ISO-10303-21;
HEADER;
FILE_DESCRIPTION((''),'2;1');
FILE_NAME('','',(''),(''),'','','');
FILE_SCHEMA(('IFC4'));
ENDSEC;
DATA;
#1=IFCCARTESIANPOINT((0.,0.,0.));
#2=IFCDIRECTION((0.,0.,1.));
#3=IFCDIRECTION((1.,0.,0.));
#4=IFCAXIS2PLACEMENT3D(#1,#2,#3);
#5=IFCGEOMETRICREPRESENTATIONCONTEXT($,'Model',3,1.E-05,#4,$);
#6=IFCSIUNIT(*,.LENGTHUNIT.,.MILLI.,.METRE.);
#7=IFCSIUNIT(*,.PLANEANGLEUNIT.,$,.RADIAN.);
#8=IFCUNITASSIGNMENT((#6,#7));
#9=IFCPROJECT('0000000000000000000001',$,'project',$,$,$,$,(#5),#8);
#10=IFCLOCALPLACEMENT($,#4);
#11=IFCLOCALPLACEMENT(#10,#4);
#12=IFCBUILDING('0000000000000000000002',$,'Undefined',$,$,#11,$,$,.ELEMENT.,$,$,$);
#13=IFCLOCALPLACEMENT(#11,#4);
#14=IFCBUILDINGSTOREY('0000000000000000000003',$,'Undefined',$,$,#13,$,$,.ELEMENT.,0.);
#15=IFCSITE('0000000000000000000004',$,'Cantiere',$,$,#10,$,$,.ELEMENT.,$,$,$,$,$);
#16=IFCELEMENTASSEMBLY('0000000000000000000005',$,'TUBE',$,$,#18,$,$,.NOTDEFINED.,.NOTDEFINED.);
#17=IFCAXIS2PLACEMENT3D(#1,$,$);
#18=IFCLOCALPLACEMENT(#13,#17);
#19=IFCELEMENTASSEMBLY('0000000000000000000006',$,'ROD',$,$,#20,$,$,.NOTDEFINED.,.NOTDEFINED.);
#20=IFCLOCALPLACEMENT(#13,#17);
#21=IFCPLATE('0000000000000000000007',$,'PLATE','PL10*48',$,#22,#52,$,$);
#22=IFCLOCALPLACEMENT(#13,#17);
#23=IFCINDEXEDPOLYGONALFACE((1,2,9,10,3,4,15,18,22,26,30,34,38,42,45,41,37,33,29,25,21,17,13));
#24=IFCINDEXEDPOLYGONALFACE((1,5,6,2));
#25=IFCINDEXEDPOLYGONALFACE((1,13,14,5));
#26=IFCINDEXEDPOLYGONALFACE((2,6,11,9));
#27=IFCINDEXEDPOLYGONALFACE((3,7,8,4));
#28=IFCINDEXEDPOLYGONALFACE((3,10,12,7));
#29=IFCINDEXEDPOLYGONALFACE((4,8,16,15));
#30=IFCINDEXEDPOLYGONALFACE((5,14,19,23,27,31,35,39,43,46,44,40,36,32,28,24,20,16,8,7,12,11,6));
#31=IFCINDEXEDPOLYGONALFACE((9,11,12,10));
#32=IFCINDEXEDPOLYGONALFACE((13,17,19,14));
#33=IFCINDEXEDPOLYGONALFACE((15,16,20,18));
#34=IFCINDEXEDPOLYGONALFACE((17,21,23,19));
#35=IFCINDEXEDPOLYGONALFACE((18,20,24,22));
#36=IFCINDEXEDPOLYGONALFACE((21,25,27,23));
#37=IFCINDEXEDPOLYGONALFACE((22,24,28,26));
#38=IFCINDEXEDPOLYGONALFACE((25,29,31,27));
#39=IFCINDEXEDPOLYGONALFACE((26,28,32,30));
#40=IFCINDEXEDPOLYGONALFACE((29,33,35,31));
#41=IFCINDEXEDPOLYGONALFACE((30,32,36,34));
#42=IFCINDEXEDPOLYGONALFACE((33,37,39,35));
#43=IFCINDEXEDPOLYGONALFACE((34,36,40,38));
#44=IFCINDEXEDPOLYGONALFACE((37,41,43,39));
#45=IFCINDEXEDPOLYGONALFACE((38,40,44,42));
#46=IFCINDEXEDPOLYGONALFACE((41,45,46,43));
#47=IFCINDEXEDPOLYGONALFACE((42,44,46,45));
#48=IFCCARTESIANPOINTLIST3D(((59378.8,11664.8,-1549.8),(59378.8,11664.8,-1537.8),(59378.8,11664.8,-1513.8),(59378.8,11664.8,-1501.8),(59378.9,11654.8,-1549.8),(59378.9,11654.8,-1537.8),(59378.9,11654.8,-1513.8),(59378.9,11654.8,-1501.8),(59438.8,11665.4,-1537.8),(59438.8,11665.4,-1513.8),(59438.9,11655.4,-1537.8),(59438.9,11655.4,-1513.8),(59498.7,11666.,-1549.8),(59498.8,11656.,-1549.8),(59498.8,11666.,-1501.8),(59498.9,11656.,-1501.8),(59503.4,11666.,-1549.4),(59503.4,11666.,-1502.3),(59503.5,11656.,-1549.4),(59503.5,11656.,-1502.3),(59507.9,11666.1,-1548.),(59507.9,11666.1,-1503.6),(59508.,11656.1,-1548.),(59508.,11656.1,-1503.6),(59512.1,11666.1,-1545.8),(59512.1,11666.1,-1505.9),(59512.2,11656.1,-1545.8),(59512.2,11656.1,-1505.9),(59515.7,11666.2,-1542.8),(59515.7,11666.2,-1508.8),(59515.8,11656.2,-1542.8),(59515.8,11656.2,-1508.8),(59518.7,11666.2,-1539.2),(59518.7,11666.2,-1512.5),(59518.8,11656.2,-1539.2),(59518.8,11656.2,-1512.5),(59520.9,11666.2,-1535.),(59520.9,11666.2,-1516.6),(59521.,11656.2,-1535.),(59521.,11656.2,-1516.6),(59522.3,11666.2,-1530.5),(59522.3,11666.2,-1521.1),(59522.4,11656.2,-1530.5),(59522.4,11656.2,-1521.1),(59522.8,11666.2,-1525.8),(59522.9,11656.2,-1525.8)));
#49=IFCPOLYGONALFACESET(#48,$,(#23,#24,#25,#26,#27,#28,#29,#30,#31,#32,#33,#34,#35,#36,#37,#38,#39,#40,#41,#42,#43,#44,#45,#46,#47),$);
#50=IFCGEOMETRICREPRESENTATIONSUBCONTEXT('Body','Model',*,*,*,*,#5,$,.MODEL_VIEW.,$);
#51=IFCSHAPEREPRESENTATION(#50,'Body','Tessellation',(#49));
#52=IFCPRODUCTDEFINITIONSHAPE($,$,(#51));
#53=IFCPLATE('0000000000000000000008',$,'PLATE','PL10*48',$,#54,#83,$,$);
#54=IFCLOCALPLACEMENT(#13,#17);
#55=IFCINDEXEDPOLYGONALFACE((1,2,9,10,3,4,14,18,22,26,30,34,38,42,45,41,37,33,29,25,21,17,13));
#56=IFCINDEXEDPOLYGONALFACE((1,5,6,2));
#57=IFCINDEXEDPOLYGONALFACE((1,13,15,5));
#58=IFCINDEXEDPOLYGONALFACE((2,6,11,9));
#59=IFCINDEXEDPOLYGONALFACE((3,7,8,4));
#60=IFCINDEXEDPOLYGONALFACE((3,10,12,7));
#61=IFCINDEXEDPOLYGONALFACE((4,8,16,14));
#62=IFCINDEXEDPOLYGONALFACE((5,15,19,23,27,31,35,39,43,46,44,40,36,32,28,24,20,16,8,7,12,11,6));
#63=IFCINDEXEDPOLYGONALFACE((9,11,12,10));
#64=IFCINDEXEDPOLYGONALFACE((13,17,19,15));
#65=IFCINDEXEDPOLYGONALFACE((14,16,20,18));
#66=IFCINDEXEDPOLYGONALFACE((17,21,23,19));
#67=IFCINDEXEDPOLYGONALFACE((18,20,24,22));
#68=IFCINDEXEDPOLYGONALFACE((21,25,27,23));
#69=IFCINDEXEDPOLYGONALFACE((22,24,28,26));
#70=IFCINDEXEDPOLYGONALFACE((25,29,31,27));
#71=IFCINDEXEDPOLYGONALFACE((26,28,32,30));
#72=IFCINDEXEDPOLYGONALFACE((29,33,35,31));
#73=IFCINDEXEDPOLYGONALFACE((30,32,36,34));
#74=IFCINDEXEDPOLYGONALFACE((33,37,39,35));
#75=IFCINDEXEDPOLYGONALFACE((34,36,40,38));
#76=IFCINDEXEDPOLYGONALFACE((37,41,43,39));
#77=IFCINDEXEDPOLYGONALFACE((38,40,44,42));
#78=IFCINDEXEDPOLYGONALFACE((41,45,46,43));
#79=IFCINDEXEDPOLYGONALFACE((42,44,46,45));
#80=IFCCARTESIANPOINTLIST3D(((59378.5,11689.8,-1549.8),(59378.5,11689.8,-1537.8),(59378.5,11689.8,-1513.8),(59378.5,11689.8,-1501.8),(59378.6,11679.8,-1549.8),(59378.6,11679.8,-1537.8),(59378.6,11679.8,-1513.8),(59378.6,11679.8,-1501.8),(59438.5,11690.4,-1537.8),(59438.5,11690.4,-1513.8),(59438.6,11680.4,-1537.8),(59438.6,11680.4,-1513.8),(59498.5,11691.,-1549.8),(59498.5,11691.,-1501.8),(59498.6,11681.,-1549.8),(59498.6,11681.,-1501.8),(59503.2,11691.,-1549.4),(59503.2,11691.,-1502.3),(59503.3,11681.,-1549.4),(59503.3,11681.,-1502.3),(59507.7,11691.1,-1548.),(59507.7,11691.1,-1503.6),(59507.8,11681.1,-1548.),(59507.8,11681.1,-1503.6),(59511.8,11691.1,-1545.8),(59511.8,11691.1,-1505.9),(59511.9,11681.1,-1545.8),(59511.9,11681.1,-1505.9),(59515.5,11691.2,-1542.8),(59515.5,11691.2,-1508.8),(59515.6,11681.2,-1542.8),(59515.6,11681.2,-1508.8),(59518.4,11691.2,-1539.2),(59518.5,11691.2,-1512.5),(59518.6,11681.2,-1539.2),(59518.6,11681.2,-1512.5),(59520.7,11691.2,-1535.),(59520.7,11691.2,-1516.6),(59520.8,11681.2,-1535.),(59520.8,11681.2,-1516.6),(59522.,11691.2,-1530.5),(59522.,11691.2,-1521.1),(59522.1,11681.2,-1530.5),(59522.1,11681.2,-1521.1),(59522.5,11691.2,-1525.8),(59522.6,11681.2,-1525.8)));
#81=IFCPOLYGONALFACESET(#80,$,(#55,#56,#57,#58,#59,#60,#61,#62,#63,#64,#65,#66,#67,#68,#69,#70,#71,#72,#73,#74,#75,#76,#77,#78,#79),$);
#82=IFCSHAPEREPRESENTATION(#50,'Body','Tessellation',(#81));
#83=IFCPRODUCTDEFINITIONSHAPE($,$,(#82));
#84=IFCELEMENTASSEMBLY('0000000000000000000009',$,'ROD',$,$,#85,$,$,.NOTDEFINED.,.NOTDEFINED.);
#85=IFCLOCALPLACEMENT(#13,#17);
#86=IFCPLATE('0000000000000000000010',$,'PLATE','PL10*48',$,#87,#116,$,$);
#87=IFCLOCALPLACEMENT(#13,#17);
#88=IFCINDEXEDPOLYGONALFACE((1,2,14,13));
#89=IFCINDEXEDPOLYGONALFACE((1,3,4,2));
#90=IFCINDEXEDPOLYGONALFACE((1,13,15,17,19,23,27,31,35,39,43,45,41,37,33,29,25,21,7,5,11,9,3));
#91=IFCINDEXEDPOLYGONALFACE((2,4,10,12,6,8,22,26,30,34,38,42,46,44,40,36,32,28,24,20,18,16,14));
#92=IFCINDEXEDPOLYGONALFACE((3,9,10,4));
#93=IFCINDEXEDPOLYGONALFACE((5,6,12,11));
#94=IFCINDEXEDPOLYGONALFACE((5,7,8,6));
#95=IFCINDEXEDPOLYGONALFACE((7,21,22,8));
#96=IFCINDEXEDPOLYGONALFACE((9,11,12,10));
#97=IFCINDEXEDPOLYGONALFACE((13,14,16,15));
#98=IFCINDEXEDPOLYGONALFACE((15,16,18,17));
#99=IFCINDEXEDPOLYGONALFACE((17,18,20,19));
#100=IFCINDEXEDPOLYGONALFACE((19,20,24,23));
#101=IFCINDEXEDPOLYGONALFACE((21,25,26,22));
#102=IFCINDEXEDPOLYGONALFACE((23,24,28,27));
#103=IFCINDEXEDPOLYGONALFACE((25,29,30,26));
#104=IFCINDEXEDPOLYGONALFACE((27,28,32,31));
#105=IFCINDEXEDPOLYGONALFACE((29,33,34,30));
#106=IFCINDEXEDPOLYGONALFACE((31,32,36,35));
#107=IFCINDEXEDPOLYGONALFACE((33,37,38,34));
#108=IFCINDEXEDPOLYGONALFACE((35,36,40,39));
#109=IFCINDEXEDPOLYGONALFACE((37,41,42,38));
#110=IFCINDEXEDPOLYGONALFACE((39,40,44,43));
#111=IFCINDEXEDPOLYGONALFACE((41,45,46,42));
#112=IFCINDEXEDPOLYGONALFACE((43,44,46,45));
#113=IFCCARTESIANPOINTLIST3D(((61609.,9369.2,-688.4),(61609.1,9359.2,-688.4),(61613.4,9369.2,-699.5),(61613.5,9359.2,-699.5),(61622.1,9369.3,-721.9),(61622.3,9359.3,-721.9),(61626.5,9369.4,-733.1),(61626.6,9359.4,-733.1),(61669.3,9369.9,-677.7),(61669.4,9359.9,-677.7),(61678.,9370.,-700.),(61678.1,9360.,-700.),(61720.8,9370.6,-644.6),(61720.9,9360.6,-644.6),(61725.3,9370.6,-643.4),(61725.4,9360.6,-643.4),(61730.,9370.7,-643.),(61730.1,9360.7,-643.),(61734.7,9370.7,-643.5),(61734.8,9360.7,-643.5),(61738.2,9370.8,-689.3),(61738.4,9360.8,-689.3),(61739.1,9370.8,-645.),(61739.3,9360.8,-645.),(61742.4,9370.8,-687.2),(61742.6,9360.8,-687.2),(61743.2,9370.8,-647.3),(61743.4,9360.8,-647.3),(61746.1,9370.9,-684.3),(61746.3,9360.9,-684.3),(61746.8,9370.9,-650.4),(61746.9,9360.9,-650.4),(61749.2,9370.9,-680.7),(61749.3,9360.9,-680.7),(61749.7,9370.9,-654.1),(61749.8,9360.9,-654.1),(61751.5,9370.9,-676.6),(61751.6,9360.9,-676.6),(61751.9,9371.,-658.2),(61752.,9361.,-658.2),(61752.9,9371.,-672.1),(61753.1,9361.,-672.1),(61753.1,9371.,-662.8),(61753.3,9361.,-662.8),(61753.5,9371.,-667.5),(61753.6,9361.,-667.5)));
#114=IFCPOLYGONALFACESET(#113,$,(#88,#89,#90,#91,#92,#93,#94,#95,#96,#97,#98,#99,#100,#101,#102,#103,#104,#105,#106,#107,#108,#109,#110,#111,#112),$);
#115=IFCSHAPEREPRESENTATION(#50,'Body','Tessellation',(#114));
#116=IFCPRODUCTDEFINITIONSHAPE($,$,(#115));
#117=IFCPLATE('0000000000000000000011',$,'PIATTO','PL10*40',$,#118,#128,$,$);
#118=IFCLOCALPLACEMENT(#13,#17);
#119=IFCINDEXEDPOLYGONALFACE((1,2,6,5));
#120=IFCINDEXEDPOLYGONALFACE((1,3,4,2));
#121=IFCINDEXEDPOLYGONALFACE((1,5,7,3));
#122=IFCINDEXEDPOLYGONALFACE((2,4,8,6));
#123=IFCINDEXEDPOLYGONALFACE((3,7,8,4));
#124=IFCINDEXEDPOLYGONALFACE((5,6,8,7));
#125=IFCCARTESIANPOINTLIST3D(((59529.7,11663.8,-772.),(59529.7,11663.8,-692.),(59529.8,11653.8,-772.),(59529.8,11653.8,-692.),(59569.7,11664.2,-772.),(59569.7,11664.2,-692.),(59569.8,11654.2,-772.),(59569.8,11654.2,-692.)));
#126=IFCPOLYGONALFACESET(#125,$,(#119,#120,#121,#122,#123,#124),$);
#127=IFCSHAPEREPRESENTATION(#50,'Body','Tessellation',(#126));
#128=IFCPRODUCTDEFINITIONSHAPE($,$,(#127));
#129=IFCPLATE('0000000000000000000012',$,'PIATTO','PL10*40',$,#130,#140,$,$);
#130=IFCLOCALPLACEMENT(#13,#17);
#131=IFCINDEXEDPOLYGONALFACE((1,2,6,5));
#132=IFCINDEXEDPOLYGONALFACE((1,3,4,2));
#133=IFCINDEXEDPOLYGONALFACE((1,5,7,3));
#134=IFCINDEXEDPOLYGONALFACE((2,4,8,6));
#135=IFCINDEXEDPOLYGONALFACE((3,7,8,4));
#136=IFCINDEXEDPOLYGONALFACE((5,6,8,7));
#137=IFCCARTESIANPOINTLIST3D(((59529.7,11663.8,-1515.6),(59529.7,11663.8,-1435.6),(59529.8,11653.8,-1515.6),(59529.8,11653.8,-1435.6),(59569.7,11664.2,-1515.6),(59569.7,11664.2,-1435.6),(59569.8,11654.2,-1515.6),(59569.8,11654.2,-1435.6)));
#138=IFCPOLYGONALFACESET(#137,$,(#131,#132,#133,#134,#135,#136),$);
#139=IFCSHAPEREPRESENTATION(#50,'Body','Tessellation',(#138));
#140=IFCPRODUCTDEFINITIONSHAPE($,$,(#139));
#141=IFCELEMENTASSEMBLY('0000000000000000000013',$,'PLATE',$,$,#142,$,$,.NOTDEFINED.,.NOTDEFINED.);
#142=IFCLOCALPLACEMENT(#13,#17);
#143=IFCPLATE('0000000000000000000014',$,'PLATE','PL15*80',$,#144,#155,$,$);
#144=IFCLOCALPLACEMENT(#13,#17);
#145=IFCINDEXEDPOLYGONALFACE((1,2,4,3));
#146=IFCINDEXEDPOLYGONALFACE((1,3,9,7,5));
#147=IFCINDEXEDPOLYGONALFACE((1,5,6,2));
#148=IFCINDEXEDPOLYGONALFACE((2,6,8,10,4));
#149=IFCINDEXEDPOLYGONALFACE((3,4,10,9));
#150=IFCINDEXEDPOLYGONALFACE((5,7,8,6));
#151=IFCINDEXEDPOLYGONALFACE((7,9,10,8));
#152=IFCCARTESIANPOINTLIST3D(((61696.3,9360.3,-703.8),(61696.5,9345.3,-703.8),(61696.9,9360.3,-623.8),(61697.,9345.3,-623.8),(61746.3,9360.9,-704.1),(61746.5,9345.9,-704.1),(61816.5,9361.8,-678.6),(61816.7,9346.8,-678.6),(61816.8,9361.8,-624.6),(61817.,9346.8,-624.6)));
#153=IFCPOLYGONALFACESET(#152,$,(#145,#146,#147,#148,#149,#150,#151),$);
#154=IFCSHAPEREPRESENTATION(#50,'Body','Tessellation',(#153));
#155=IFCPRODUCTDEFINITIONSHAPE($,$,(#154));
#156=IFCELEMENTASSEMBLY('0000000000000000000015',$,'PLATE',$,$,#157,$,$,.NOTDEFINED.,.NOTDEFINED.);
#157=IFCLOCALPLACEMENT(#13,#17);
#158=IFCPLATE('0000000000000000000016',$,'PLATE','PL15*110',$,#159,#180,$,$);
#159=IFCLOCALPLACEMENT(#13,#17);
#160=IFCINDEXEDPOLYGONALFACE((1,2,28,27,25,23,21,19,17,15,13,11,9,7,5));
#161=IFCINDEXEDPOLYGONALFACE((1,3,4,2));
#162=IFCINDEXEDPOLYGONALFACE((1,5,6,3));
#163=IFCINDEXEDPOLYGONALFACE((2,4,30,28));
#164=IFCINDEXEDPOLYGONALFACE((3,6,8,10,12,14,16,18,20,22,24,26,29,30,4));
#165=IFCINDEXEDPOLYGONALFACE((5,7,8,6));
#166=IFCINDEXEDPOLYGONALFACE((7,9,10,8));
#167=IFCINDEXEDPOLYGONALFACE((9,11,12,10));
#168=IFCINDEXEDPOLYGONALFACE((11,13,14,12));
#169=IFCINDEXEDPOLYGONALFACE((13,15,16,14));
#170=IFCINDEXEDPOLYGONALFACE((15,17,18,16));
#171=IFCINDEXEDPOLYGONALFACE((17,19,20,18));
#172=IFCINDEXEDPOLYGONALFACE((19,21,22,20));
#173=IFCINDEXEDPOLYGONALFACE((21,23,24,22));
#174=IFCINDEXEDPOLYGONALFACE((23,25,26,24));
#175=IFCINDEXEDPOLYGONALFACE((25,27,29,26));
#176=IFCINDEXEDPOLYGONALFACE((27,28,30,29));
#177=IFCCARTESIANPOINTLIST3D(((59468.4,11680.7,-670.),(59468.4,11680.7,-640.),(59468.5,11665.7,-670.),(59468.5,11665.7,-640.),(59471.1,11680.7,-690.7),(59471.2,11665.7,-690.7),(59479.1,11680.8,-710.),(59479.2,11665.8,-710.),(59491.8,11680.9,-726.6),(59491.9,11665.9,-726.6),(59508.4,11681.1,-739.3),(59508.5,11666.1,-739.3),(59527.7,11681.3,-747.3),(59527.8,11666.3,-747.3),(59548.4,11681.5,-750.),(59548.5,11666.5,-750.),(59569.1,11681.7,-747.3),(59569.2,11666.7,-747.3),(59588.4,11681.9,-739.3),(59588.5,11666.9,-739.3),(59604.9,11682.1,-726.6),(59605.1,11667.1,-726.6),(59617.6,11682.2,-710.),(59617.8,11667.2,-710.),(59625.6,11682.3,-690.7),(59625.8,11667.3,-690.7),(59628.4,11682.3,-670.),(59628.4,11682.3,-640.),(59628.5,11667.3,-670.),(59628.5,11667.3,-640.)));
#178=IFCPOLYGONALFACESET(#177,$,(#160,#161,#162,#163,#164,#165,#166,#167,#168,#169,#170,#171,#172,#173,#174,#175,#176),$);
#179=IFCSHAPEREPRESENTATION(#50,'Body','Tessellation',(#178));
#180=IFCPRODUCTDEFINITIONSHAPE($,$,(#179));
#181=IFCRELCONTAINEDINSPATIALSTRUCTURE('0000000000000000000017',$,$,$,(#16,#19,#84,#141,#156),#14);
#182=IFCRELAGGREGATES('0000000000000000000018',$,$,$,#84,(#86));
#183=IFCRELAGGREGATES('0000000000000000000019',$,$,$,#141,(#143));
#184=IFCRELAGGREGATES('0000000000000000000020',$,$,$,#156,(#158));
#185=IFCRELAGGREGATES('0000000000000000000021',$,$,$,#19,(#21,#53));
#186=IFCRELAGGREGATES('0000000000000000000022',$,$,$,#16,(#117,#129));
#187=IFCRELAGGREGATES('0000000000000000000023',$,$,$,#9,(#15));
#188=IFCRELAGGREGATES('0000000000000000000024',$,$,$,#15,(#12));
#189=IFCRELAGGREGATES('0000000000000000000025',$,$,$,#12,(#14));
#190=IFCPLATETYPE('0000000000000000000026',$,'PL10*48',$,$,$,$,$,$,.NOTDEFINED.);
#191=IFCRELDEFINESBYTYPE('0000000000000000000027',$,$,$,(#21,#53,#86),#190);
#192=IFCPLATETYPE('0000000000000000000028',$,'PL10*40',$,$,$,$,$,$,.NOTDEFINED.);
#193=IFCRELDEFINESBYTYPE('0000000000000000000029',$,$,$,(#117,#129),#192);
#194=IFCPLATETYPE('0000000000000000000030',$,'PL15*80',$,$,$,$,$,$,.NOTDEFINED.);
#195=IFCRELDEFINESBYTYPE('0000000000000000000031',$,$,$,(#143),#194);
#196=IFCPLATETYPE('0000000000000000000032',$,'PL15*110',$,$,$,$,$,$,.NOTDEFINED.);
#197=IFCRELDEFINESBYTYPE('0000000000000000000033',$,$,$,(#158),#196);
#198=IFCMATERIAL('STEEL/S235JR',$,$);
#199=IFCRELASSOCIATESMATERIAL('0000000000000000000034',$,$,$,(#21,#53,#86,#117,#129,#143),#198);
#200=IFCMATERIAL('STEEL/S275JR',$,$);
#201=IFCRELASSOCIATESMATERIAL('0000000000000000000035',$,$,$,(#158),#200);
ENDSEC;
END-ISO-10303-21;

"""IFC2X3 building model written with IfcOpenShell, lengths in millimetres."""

from ifc_helpers import new_model, si_unit, frame, frame_2d, origin_with_axes, place, context, subcontext, project, spatial, polyline, circle_curve, parameter, trimmed, segment, composite_curve, outline, extrude, material, type_object, element, aggregate, save


model = new_model("IFC2X3")

# Units and contexts
model_context = context("Model", 3, precision=1e-05, world=origin_with_axes())
body_context = subcontext(model_context, "Body", "Model", "MODEL_VIEW")
ifc_project = project(units=[si_unit("LENGTHUNIT", "METRE", prefix="MILLI"), si_unit("PLANEANGLEUNIT", "RADIAN")], contexts=[model_context])

# Site, building, storey
site_placement = place(None, origin_with_axes())
site = spatial("IfcSite", under=ifc_project, at=site_placement, Name="Cantiere", CompositionType="ELEMENT")
building_placement = place(site_placement, origin_with_axes())
building = spatial("IfcBuilding", under=site, at=building_placement, Name="Undefined", CompositionType="ELEMENT")
storey_placement = place(building_placement, origin_with_axes())
storey = spatial("IfcBuildingStorey", under=building, at=storey_placement, Name="Undefined", CompositionType="ELEMENT", Elevation=0.0)

# Element assembly
assembly_1_placement = place(storey_placement, origin_with_axes())
assembly_1 = element("IfcElementAssembly", 1, at=assembly_1_placement, inside=storey, Name="TUBE", AssemblyPlace="NOTDEFINED", PredefinedType="NOTDEFINED")
ifc_material_1 = material(Name="STEEL/S235JR")

# Shared definitions
plate_type_1 = type_object("IfcPlateType", Name="PL10*48", PredefinedType="NOTDEFINED")

# Element assembly, plates
assembly_2_placement = place(storey_placement, origin_with_axes())
assembly_2 = element("IfcElementAssembly", 2, at=assembly_2_placement, inside=storey, Name="ROD", AssemblyPlace="NOTDEFINED", PredefinedType="NOTDEFINED")
plate_1_placement = place(assembly_2_placement, frame((59378.8, 11659.8, -1549.8), z_axis=(0.010137, -0.999949, 0.0), x_axis=(0.999949, 0.010137, -0.000205)))
plate_1 = element("IfcPlate", 3, at=plate_1_placement, type_object=plate_type_1, material=ifc_material_1, Name="PLATE", Description="PL10*48", context=body_context, shape_type="SweptSolid", body=[
    extrude(outline(polyline([(0.0, 0.0), (120.0, 0.0), (124.7, 0.5), (129.2, 1.8), (133.3, 4.0), (137.0, 7.0), (140.0, 10.7), (142.2, 14.8), (143.5, 19.3), (144.0, 24.0), (144.0, 24.0), (143.5, 28.7), (142.2, 33.2), (140.0, 37.3), (137.0, 41.0), (133.3, 44.0), (129.2, 46.2), (124.7, 47.5), (120.0, 48.0), (0.0, 48.0), (0.0, 36.0), (60.0, 36.0), (60.0, 12.0), (0.0, 12.0), (0.0, 0.0)])), frame((0.0, 0.0, -5.0), z_axis=(0.0, 0.0, 1.0), x_axis=(1.0, 0.0, 0.0)), (0.0, 0.0, 1.0), 10.0),
])
plate_2_placement = place(assembly_2_placement, frame((59378.5, 11684.8, -1549.8), z_axis=(0.010137, -0.999949, 0.0), x_axis=(0.999949, 0.010137, -0.000205)))
plate_2 = element("IfcPlate", 4, at=plate_2_placement, type_object=plate_type_1, material=ifc_material_1, Name="PLATE", Description="PL10*48", context=body_context, shape_type="SweptSolid", body=[
    extrude(outline(polyline([(0.0, 0.0), (120.0, 0.0), (124.7, 0.5), (129.2, 1.8), (133.3, 4.0), (137.0, 7.0), (140.0, 10.7), (142.2, 14.8), (143.5, 19.3), (144.0, 24.0), (144.0, 24.0), (143.5, 28.7), (142.2, 33.2), (140.0, 37.3), (137.0, 41.0), (133.3, 44.0), (129.2, 46.2), (124.7, 47.5), (120.0, 48.0), (0.0, 48.0), (0.0, 36.0), (60.0, 36.0), (60.0, 12.0), (0.0, 12.0), (0.0, 0.0)])), frame((0.0, 0.0, -5.0), z_axis=(0.0, 0.0, 1.0), x_axis=(1.0, 0.0, 0.0)), (0.0, 0.0, 1.0), 10.0),
])

# Element assembly, plate
assembly_3_placement = place(storey_placement, origin_with_axes())
assembly_3 = element("IfcElementAssembly", 5, at=assembly_3_placement, inside=storey, Name="ROD", AssemblyPlace="NOTDEFINED", PredefinedType="NOTDEFINED")
plate_3_placement = place(assembly_3_placement, frame((61609.1, 9364.2, -688.4), z_axis=(-0.012617, 0.99992, 0.0), x_axis=(0.931215, 0.01175, 0.364281)))
plate_3 = element("IfcPlate", 6, at=plate_3_placement, type_object=plate_type_1, material=ifc_material_1, Name="PLATE", Description="PL10*48", context=body_context, shape_type="SweptSolid", body=[
    extrude(outline(polyline([(0.0, 0.0), (120.0, 0.0), (124.7, 0.5), (129.2, 1.8), (133.3, 4.0), (137.0, 7.0), (140.0, 10.7), (142.2, 14.8), (143.5, 19.3), (144.0, 24.0), (144.0, 24.0), (143.5, 28.7), (142.2, 33.2), (140.0, 37.3), (137.0, 41.0), (133.3, 44.0), (129.2, 46.2), (124.7, 47.5), (120.0, 48.0), (0.0, 48.0), (0.0, 36.0), (60.0, 36.0), (60.0, 12.0), (0.0, 12.0), (0.0, 0.0)])), frame((0.0, 0.0, -5.0), z_axis=(0.0, 0.0, 1.0), x_axis=(1.0, 0.0, 0.0)), (0.0, 0.0, 1.0), 10.0),
])
aggregate(assembly_3, [plate_3])

# Plates
plate_type_2 = type_object("IfcPlateType", Name="PL10*40", PredefinedType="NOTDEFINED")
plate_4_placement = place(assembly_1_placement, frame((59569.7, 11659.2, -772.0), z_axis=(0.01014, -0.999949, 0.0), x_axis=(0.0, 0.0, 1.0)))
plate_4 = element("IfcPlate", 7, at=plate_4_placement, type_object=plate_type_2, material=ifc_material_1, Name="PIATTO", Description="PL10*40", context=body_context, shape_type="SweptSolid", body=[
    extrude(outline(polyline([(0.0, 0.0), (80.0, 0.0), (80.0, 40.0), (0.0, 40.0), (0.0, 0.0)])), frame((0.0, 0.0, -5.0), z_axis=(0.0, 0.0, 1.0), x_axis=(1.0, 0.0, 0.0)), (0.0, 0.0, 1.0), 10.0),
])
plate_5_placement = place(assembly_1_placement, frame((59529.7, 11658.8, -1435.6), z_axis=(0.01014, -0.999949, 0.0), x_axis=(0.0, 0.000001, -1.0)))
plate_5 = element("IfcPlate", 8, at=plate_5_placement, type_object=plate_type_2, material=ifc_material_1, Name="PIATTO", Description="PL10*40", context=body_context, shape_type="SweptSolid", body=[
    extrude(outline(polyline([(0.0, 0.0), (80.0, 0.0), (80.0, 40.0), (0.0, 40.0), (0.0, 0.0)])), frame((0.0, 0.0, -5.0), z_axis=(0.0, 0.0, 1.0), x_axis=(1.0, 0.0, 0.0)), (0.0, 0.0, 1.0), 10.0),
])

# Element assemblies, plates
assembly_4_placement = place(storey_placement, origin_with_axes())
assembly_4 = element("IfcElementAssembly", 9, at=assembly_4_placement, inside=storey, Name="PLATE", AssemblyPlace="NOTDEFINED", PredefinedType="NOTDEFINED")
plate_type_3 = type_object("IfcPlateType", Name="PL15*80", PredefinedType="NOTDEFINED")
plate_6_placement = place(assembly_4_placement, frame((61696.9, 9352.8, -623.8), z_axis=(-0.012617, 0.99992, 0.0), x_axis=(0.999897, 0.012617, -0.006865)))
plate_6 = element("IfcPlate", 10, at=plate_6_placement, type_object=plate_type_3, material=ifc_material_1, Name="PLATE", Description="PL15*80", context=body_context, shape_type="SweptSolid", body=[
    extrude(outline(polyline([(0.0, 0.0), (120.0, 0.0), (120.0, 54.0), (50.0, 80.0), (0.0, 80.0), (0.0, 0.0)])), frame((0.0, 0.0, -7.5), z_axis=(0.0, 0.0, 1.0), x_axis=(1.0, 0.0, 0.0)), (0.0, 0.0, 1.0), 15.0),
])
aggregate(assembly_4, [plate_6])
assembly_5_placement = place(storey_placement, origin_with_axes())
assembly_5 = element("IfcElementAssembly", 11, at=assembly_5_placement, inside=storey, Name="PLATE", AssemblyPlace="NOTDEFINED", PredefinedType="NOTDEFINED")
ifc_material_2 = material(Name="STEEL/S275JR")
plate_type_4 = type_object("IfcPlateType", Name="PL15*110", PredefinedType="NOTDEFINED")
plate_7_placement = place(assembly_5_placement, frame((59468.4, 11673.2, -640.0), z_axis=(-0.010139, 0.999949, 0.0), x_axis=(0.999949, 0.010139, 0.0)))
plate_7 = element("IfcPlate", 12, at=plate_7_placement, type_object=plate_type_4, material=ifc_material_2, Name="PLATE", Description="PL15*110", context=body_context, shape_type="SweptSolid", body=[
    extrude(outline(composite_curve([segment(polyline([(0.0, 0.0), (160.0, 0.0), (160.0, 30.0)]), True, "CONTINUOUS"), segment(trimmed(circle_curve(frame_2d((80.0, 30.0), x_axis=(1.0, 0.0)), 80.0), [parameter(0.0)], [parameter(1.570796)], True, "PARAMETER"), True, "CONTINUOUS"), segment(trimmed(circle_curve(frame_2d((80.0, 30.0), x_axis=(0.0, 1.0)), 80.0), [parameter(0.0)], [parameter(1.570796)], True, "PARAMETER"), True, "CONTINUOUS"), segment(polyline([(0.0, 30.0), (0.0, 0.0)]), True, "CONTINUOUS")], self_intersect=True)), frame((0.0, 0.0, -7.5), z_axis=(0.0, 0.0, 1.0), x_axis=(1.0, 0.0, 0.0)), (0.0, 0.0, 1.0), 15.0),
])
aggregate(assembly_5, [plate_7])

aggregate(assembly_2, [plate_1, plate_2])
aggregate(assembly_1, [plate_4, plate_5])

save(model, "model.ifc")
